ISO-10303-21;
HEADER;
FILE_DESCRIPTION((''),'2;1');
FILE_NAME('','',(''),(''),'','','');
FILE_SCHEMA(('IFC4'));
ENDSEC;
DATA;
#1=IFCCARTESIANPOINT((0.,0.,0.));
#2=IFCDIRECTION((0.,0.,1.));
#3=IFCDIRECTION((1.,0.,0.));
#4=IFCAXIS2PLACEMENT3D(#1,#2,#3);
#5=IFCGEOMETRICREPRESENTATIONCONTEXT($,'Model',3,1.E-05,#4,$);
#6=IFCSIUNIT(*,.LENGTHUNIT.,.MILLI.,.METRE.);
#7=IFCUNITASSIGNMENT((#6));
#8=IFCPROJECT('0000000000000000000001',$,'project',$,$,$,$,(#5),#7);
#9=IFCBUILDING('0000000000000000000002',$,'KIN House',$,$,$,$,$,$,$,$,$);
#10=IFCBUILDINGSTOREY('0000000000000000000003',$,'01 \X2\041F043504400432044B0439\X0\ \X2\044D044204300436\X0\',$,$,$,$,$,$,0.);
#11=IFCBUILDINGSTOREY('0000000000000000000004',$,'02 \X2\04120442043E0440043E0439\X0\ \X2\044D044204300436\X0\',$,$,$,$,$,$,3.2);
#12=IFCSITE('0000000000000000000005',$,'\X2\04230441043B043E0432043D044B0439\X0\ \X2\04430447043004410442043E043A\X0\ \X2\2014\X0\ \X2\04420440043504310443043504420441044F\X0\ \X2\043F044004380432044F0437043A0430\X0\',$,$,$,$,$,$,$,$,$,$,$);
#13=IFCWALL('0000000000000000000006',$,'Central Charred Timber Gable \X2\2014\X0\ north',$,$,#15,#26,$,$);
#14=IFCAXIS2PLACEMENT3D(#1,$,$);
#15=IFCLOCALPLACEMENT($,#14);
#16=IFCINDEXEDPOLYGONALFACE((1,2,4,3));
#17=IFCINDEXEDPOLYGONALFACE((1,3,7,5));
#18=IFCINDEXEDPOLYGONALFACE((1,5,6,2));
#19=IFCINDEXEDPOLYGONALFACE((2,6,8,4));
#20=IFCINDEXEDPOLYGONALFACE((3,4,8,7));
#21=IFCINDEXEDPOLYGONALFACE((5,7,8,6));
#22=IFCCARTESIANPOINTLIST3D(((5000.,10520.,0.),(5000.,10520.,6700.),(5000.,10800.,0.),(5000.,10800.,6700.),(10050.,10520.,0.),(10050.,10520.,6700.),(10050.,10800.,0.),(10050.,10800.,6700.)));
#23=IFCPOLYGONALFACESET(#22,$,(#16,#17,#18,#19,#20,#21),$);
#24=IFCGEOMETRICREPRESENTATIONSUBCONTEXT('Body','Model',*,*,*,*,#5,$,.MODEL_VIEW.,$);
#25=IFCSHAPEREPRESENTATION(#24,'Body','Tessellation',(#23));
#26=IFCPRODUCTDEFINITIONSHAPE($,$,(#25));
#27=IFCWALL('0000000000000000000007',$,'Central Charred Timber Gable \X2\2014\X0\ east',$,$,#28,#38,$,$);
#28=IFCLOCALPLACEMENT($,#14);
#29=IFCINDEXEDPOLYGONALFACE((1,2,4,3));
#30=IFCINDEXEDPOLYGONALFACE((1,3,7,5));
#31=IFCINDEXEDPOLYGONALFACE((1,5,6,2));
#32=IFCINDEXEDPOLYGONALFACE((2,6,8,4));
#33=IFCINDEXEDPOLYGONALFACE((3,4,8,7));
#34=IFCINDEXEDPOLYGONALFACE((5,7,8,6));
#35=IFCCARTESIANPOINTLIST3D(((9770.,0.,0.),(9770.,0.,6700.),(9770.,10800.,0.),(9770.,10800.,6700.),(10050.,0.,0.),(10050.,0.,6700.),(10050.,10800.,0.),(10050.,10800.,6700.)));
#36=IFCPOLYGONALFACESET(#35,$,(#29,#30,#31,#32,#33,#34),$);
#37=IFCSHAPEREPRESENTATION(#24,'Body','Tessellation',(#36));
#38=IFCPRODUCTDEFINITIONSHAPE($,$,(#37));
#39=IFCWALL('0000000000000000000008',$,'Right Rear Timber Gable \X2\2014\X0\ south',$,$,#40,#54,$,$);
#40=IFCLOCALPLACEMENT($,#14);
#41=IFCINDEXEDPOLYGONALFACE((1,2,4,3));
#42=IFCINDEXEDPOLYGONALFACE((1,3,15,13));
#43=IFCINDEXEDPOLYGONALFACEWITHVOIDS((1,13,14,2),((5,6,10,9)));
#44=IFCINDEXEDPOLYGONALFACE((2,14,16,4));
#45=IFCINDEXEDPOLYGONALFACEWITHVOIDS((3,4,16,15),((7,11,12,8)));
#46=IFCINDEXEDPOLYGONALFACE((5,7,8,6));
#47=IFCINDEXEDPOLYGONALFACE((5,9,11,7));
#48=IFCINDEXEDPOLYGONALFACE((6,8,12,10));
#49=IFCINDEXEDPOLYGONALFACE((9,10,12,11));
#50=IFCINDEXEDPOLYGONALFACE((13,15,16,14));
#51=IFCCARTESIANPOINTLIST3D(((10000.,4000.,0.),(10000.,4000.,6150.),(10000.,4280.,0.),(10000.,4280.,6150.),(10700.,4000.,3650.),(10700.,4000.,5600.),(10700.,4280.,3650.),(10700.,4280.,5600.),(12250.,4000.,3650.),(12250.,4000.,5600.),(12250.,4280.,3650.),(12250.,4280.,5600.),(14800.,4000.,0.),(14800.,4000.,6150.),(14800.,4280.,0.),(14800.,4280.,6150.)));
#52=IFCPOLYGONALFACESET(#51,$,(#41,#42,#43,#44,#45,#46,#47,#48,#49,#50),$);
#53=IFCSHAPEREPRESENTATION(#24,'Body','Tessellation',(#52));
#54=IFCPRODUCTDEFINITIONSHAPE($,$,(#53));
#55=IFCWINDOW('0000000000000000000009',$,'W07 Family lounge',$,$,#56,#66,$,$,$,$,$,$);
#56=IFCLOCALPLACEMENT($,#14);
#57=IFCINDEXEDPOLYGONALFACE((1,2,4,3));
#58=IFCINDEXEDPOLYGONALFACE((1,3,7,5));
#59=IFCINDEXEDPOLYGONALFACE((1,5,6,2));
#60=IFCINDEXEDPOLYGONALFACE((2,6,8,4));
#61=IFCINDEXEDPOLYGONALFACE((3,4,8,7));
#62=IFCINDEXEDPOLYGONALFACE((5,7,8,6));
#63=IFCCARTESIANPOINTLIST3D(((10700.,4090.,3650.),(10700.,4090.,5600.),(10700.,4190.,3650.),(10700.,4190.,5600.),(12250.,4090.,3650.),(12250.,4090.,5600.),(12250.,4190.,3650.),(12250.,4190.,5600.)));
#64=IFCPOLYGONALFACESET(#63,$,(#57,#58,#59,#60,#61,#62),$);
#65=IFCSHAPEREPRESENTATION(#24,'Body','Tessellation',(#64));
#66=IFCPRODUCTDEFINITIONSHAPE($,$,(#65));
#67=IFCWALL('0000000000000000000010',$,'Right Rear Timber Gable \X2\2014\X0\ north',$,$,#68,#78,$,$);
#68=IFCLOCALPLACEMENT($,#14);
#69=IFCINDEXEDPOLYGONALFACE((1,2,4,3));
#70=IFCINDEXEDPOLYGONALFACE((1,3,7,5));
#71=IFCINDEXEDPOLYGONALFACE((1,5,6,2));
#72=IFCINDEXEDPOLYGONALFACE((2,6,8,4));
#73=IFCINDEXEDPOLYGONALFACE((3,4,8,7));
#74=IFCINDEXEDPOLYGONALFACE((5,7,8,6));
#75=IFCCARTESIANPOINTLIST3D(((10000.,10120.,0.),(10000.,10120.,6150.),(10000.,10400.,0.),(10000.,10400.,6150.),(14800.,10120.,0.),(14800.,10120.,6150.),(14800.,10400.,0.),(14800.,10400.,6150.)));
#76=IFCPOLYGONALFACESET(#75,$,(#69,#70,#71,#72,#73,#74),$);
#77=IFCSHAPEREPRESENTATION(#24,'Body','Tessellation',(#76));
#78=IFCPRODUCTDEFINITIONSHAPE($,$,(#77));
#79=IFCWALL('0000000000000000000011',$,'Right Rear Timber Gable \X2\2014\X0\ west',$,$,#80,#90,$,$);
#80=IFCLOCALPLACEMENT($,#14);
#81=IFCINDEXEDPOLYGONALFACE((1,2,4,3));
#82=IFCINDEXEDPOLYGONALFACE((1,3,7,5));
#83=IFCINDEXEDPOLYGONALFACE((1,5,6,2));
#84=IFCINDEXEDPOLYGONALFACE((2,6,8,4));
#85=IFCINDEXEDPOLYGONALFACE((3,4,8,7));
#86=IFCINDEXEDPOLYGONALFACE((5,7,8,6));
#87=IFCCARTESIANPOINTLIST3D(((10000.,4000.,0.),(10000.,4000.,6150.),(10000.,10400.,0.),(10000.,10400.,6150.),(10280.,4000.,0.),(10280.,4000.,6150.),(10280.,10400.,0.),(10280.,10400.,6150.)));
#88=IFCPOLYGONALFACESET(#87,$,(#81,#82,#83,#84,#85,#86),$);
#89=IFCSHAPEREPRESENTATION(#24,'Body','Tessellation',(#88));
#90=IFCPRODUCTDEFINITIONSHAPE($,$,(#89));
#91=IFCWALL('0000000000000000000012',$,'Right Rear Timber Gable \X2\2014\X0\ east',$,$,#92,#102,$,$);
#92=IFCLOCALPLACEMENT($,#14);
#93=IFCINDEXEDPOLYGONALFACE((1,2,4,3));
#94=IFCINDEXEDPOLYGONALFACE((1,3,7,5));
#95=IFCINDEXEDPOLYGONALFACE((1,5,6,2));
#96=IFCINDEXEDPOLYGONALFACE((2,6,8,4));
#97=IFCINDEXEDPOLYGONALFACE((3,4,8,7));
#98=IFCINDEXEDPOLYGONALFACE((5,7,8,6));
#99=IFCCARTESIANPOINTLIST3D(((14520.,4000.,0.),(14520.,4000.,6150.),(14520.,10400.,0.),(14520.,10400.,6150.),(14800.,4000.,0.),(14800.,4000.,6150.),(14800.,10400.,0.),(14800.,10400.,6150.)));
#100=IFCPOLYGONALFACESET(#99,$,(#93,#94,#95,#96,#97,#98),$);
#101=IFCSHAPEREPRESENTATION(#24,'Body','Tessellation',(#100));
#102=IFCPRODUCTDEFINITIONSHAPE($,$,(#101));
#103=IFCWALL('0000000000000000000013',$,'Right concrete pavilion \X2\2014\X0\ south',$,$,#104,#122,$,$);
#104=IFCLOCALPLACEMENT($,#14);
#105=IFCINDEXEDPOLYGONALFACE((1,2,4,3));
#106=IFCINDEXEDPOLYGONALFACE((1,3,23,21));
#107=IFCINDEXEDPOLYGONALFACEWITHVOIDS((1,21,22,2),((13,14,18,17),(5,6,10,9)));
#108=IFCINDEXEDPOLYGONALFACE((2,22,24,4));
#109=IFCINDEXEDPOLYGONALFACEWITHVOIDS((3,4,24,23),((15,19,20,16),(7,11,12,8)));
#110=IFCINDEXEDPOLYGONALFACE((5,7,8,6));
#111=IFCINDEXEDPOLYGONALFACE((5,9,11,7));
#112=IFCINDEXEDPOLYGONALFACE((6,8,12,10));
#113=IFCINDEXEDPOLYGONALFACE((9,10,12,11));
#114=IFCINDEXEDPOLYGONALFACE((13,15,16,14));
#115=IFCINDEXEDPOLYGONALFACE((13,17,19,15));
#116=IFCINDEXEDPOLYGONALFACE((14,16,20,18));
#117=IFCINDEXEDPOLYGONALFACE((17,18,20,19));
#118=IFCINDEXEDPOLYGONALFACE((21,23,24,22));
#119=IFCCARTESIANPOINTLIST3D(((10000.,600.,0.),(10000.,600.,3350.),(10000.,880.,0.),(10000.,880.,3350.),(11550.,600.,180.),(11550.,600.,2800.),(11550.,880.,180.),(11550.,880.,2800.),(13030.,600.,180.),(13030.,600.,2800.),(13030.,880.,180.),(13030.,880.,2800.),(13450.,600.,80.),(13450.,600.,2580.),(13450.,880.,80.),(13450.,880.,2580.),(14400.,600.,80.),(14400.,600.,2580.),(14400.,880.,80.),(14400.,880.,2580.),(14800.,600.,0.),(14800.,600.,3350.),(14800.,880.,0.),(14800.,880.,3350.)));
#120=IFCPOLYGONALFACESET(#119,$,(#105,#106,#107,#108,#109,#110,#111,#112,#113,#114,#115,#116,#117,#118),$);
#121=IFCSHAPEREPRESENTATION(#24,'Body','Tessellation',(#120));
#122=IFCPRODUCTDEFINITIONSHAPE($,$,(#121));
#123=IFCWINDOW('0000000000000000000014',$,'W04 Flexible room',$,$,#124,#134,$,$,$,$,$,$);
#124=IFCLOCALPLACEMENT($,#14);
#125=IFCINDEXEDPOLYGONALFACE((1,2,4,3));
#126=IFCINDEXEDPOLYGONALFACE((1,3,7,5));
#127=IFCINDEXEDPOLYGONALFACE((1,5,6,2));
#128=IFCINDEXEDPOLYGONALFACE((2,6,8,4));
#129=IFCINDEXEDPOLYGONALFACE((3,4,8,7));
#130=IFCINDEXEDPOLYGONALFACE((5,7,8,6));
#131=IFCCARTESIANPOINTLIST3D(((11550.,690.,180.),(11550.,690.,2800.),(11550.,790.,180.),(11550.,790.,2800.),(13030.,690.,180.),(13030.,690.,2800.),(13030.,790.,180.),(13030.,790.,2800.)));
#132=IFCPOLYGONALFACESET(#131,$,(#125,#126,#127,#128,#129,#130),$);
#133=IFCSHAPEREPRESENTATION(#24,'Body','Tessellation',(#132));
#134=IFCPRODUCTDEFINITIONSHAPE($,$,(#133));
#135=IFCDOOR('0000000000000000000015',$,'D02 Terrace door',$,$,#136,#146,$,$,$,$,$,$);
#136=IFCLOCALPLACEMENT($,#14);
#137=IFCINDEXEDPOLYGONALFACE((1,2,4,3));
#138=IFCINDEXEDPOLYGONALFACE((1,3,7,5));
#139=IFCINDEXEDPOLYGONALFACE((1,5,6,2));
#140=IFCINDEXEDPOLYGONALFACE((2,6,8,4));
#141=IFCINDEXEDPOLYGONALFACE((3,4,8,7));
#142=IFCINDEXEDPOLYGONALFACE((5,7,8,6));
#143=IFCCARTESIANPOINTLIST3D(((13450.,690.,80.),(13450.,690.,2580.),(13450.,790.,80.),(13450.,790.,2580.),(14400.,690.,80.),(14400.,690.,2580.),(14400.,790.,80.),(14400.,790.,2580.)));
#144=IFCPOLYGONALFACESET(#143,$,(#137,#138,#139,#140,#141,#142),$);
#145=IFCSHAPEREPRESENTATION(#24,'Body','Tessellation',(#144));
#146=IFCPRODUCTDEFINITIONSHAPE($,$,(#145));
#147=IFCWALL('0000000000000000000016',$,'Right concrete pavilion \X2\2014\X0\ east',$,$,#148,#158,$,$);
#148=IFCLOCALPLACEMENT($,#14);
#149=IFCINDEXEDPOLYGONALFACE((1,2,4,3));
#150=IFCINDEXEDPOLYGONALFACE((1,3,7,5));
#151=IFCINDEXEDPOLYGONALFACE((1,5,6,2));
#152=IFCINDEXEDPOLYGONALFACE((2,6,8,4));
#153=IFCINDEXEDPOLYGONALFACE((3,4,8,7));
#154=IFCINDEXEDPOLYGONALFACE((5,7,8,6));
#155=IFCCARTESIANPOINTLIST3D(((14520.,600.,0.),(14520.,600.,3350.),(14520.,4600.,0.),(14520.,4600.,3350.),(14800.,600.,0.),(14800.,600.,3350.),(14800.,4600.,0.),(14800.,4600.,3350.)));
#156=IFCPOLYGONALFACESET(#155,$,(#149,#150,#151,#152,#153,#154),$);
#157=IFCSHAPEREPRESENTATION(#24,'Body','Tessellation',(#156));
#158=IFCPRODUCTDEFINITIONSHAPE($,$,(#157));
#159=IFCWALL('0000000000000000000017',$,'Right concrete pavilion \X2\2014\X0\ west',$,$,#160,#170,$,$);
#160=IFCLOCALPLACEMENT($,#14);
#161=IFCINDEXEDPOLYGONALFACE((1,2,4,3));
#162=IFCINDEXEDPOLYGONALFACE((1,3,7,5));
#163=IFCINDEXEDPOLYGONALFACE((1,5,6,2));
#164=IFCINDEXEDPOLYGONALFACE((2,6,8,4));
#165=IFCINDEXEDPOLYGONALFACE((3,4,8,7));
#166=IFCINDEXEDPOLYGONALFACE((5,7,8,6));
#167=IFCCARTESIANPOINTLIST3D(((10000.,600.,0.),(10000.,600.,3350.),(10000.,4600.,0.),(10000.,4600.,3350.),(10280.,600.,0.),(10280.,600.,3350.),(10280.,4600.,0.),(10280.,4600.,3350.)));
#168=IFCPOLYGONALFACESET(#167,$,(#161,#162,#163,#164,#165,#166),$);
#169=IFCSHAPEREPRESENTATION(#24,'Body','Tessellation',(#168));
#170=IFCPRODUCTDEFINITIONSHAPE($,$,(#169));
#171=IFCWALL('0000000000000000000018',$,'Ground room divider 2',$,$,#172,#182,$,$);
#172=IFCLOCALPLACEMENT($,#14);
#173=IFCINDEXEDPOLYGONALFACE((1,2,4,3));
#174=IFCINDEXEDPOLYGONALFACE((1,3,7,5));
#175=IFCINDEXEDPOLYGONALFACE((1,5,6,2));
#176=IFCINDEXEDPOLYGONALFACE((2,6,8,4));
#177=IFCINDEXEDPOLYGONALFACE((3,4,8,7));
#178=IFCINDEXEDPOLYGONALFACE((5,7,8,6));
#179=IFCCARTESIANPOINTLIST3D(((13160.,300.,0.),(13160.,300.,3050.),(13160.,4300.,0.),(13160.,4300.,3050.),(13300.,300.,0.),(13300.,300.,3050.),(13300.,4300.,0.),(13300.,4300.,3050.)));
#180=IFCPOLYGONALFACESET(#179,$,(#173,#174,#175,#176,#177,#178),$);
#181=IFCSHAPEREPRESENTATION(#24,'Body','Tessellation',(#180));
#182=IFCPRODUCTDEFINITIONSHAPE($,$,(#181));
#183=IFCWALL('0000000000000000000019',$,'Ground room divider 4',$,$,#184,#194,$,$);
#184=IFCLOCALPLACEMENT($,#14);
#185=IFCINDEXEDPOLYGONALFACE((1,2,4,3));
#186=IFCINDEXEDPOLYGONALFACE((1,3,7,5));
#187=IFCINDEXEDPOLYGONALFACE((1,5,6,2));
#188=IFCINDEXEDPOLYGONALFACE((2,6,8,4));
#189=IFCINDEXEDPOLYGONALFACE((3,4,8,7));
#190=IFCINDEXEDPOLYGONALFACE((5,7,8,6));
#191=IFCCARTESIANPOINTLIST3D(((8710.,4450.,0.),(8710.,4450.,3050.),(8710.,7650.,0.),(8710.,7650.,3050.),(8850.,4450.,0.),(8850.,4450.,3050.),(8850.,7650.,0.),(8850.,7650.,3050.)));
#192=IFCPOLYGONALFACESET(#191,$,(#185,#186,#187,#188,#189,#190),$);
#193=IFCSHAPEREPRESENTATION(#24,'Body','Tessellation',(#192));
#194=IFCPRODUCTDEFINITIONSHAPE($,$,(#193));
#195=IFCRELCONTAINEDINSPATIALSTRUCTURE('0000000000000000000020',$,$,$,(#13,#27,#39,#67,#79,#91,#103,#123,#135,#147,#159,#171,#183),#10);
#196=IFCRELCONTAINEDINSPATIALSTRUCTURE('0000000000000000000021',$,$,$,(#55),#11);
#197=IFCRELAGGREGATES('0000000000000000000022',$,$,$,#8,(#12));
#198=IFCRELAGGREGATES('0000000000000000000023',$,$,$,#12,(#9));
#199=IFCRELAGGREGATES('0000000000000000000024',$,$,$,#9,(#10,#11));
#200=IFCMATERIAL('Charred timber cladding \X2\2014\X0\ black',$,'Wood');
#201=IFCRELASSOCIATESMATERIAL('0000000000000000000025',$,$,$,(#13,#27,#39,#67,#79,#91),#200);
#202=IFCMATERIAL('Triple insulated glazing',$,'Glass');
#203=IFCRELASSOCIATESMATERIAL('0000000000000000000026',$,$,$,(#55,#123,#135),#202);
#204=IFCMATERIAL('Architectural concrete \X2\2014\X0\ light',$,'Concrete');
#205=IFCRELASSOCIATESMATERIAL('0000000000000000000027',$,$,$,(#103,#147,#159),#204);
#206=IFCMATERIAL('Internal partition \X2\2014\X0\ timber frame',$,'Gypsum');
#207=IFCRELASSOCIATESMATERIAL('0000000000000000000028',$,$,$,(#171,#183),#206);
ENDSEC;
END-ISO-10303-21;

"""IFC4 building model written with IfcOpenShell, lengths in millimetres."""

from ifc_helpers import new_model, si_unit, frame, origin_with_axes, place, context, subcontext, project, spatial, indexed_curve, outline, extrude, material, element, fill, save


model = new_model("IFC4")

# Units and contexts
model_context = context("Model", 3, precision=1e-05, world=origin_with_axes())
body_context = subcontext(model_context, "Body", "Model", "MODEL_VIEW")
ifc_project = project(units=[si_unit("LENGTHUNIT", "METRE", prefix="MILLI")], contexts=[model_context])

# Site, building, storey
site = spatial("IfcSite", under=ifc_project, Name="Условный участок — требуется привязка")
building = spatial("IfcBuilding", under=site, Name="KIN House")
storey_1 = spatial("IfcBuildingStorey", under=building, Name="01 Первый этаж", Elevation=0.0)

# Walls
ifc_material_1 = material(Name="Charred timber cladding — black", Category="Wood")
wall_1_placement = place(None, frame((10050.0, 10800.0, 0.0), z_axis=(0.0, 0.0, 1.0), x_axis=(-1.0, 0.0, 0.0)))
element("IfcWall", 1, at=wall_1_placement, inside=storey_1, material=ifc_material_1, Name="Central Charred Timber Gable — north", context=body_context, shape_type="SweptSolid", body=[
    extrude(outline(indexed_curve([(0.0, 0.0), (0.0, 280.0), (5050.0, 280.0), (5050.0, 0.0), (0.0, 0.0)], self_intersect=False)), origin_with_axes(), (0.0, 0.0, 1.0), 6700.0),
])
wall_2_placement = place(None, frame((10050.0, 0.0, 0.0), z_axis=(0.0, 0.0, 1.0), x_axis=(0.0, 1.0, 0.0)))
element("IfcWall", 2, at=wall_2_placement, inside=storey_1, material=ifc_material_1, Name="Central Charred Timber Gable — east", context=body_context, shape_type="SweptSolid", body=[
    extrude(outline(indexed_curve([(0.0, 0.0), (0.0, 280.0), (10800.0, 280.0), (10800.0, 0.0), (0.0, 0.0)], self_intersect=False)), origin_with_axes(), (0.0, 0.0, 1.0), 6700.0),
])

# Wall, opening
wall_3_placement = place(None, frame((10000.0, 4000.0, 0.0), z_axis=(0.0, 0.0, 1.0), x_axis=(1.0, 0.0, 0.0)))
wall_3 = element("IfcWall", 3, at=wall_3_placement, inside=storey_1, material=ifc_material_1, Name="Right Rear Timber Gable — south", context=body_context, shape_type="SweptSolid", body=[
    extrude(outline(indexed_curve([(0.0, 0.0), (0.0, 280.0), (4800.0, 280.0), (4800.0, 0.0), (0.0, 0.0)], self_intersect=False)), origin_with_axes(), (0.0, 0.0, 1.0), 6150.0),
])
opening_1_placement = place(wall_3_placement, frame((700.0, 0.0, 3650.0), z_axis=(0.0, 0.0, 1.0), x_axis=(1.0, 0.0, 0.0)))
opening_1 = element("IfcOpeningElement", 4, at=opening_1_placement, cuts=wall_3, context=body_context, shape_type="SweptSolid", body=[
    extrude(outline(indexed_curve([(0.0, 0.0), (0.0, 380.0), (1550.0, 380.0), (1550.0, 0.0), (0.0, 0.0)], self_intersect=False)), origin_with_axes(), (0.0, 0.0, 1.0), 1950.0),
])

# Shared definitions
storey_2 = spatial("IfcBuildingStorey", under=building, Name="02 Второй этаж", Elevation=3.2)

# Window
ifc_material_2 = material(Name="Triple insulated glazing", Category="Glass")
window_1_placement = place(None, frame((10700.0, 4090.0, 3650.0), z_axis=(0.0, 0.0, 1.0), x_axis=(1.0, 0.0, 0.0)))
window_1 = element("IfcWindow", 5, at=window_1_placement, inside=storey_2, material=ifc_material_2, Name="W07 Family lounge", context=body_context, shape_type="SweptSolid", body=[
    extrude(outline(indexed_curve([(0.0, 0.0), (0.0, 100.0), (1550.0, 100.0), (1550.0, 0.0), (0.0, 0.0)], self_intersect=False)), origin_with_axes(), (0.0, 0.0, 1.0), 1950.0),
])
fill(opening_1, window_1)

# Walls
wall_4_placement = place(None, frame((14800.0, 10400.0, 0.0), z_axis=(0.0, 0.0, 1.0), x_axis=(-1.0, 0.0, 0.0)))
element("IfcWall", 6, at=wall_4_placement, inside=storey_1, material=ifc_material_1, Name="Right Rear Timber Gable — north", context=body_context, shape_type="SweptSolid", body=[
    extrude(outline(indexed_curve([(0.0, 0.0), (0.0, 280.0), (4800.0, 280.0), (4800.0, 0.0), (0.0, 0.0)], self_intersect=False)), origin_with_axes(), (0.0, 0.0, 1.0), 6150.0),
])
for number, where, z_axis, x_axis, name in (
    (7, (10000.0, 10400.0, 0.0), (0.0, 0.0, 1.0), (0.0, -1.0, 0.0), "Right Rear Timber Gable — west"),
    (8, (14800.0, 4000.0, 0.0), (0.0, 0.0, 1.0), (0.0, 1.0, 0.0), "Right Rear Timber Gable — east"),
):
    element("IfcWall", number, at=place(None, frame(where, z_axis=z_axis, x_axis=x_axis)), inside=storey_1, material=ifc_material_1, Name=name, context=body_context, shape_type="SweptSolid", body=[
        extrude(outline(indexed_curve([(0.0, 0.0), (0.0, 280.0), (6400.0, 280.0), (6400.0, 0.0), (0.0, 0.0)], self_intersect=False)), origin_with_axes(), (0.0, 0.0, 1.0), 6150.0),
    ])

# Wall, openings, window, door
ifc_material_3 = material(Name="Architectural concrete — light", Category="Concrete")
wall_5_placement = place(None, frame((10000.0, 600.0, 0.0), z_axis=(0.0, 0.0, 1.0), x_axis=(1.0, 0.0, 0.0)))
wall_5 = element("IfcWall", 9, at=wall_5_placement, inside=storey_1, material=ifc_material_3, Name="Right concrete pavilion — south", context=body_context, shape_type="SweptSolid", body=[
    extrude(outline(indexed_curve([(0.0, 0.0), (0.0, 280.0), (4800.0, 280.0), (4800.0, 0.0), (0.0, 0.0)], self_intersect=False)), origin_with_axes(), (0.0, 0.0, 1.0), 3350.0),
])
opening_2_placement = place(wall_5_placement, frame((1550.0, 0.0, 180.0), z_axis=(0.0, 0.0, 1.0), x_axis=(1.0, 0.0, 0.0)))
opening_2 = element("IfcOpeningElement", 10, at=opening_2_placement, cuts=wall_5, context=body_context, shape_type="SweptSolid", body=[
    extrude(outline(indexed_curve([(0.0, 0.0), (0.0, 380.0), (1480.0, 380.0), (1480.0, 0.0), (0.0, 0.0)], self_intersect=False)), origin_with_axes(), (0.0, 0.0, 1.0), 2620.0),
])
opening_3_placement = place(wall_5_placement, frame((3450.0, 0.0, 80.0), z_axis=(0.0, 0.0, 1.0), x_axis=(1.0, 0.0, 0.0)))
opening_3 = element("IfcOpeningElement", 11, at=opening_3_placement, cuts=wall_5, context=body_context, shape_type="SweptSolid", body=[
    extrude(outline(indexed_curve([(0.0, 0.0), (0.0, 380.0), (950.0, 380.0), (950.0, 0.0), (0.0, 0.0)], self_intersect=False)), origin_with_axes(), (0.0, 0.0, 1.0), 2500.0),
])
window_2_placement = place(None, frame((11550.0, 690.0, 180.0), z_axis=(0.0, 0.0, 1.0), x_axis=(1.0, 0.0, 0.0)))
window_2 = element("IfcWindow", 12, at=window_2_placement, inside=storey_1, material=ifc_material_2, Name="W04 Flexible room", context=body_context, shape_type="SweptSolid", body=[
    extrude(outline(indexed_curve([(0.0, 0.0), (0.0, 100.0), (1480.0, 100.0), (1480.0, 0.0), (0.0, 0.0)], self_intersect=False)), origin_with_axes(), (0.0, 0.0, 1.0), 2620.0),
])
fill(opening_2, window_2)
door_placement = place(None, frame((13450.0, 690.0, 80.0), z_axis=(0.0, 0.0, 1.0), x_axis=(1.0, 0.0, 0.0)))
door = element("IfcDoor", 13, at=door_placement, inside=storey_1, material=ifc_material_2, Name="D02 Terrace door", context=body_context, shape_type="SweptSolid", body=[
    extrude(outline(indexed_curve([(0.0, 0.0), (0.0, 100.0), (950.0, 100.0), (950.0, 0.0), (0.0, 0.0)], self_intersect=False)), origin_with_axes(), (0.0, 0.0, 1.0), 2500.0),
])
fill(opening_3, door)

# Walls
for number, where, z_axis, x_axis, name in (
    (14, (14800.0, 600.0, 0.0), (0.0, 0.0, 1.0), (0.0, 1.0, 0.0), "Right concrete pavilion — east"),
    (15, (10000.0, 4600.0, 0.0), (0.0, 0.0, 1.0), (0.0, -1.0, 0.0), "Right concrete pavilion — west"),
):
    element("IfcWall", number, at=place(None, frame(where, z_axis=z_axis, x_axis=x_axis)), inside=storey_1, material=ifc_material_3, Name=name, context=body_context, shape_type="SweptSolid", body=[
        extrude(outline(indexed_curve([(0.0, 0.0), (0.0, 280.0), (4000.0, 280.0), (4000.0, 0.0), (0.0, 0.0)], self_intersect=False)), origin_with_axes(), (0.0, 0.0, 1.0), 3350.0),
    ])
ifc_material_4 = material(Name="Internal partition — timber frame", Category="Gypsum")
wall_6_placement = place(None, frame((13300.0, 300.0, 0.0), z_axis=(0.0, 0.0, 1.0), x_axis=(0.0, 1.0, 0.0)))
element("IfcWall", 16, at=wall_6_placement, inside=storey_1, material=ifc_material_4, Name="Ground room divider 2", context=body_context, shape_type="SweptSolid", body=[
    extrude(outline(indexed_curve([(0.0, 0.0), (0.0, 140.0), (4000.0, 140.0), (4000.0, 0.0), (0.0, 0.0)], self_intersect=False)), origin_with_axes(), (0.0, 0.0, 1.0), 3050.0),
])
for number, where, z_axis, x_axis, name in (
    (17, (8850.0, 4450.0, 0.0), (0.0, 0.0, 1.0), (0.0, 1.0, 0.0), "Ground room divider 4"),
):
    element("IfcWall", number, at=place(None, frame(where, z_axis=z_axis, x_axis=x_axis)), inside=storey_1, material=ifc_material_4, Name=name, context=body_context, shape_type="SweptSolid", body=[
        extrude(outline(indexed_curve([(0.0, 0.0), (0.0, 140.0), (3200.0, 140.0), (3200.0, 0.0), (0.0, 0.0)], self_intersect=False)), origin_with_axes(), (0.0, 0.0, 1.0), 3050.0),
    ])

save(model, "model.ifc")
